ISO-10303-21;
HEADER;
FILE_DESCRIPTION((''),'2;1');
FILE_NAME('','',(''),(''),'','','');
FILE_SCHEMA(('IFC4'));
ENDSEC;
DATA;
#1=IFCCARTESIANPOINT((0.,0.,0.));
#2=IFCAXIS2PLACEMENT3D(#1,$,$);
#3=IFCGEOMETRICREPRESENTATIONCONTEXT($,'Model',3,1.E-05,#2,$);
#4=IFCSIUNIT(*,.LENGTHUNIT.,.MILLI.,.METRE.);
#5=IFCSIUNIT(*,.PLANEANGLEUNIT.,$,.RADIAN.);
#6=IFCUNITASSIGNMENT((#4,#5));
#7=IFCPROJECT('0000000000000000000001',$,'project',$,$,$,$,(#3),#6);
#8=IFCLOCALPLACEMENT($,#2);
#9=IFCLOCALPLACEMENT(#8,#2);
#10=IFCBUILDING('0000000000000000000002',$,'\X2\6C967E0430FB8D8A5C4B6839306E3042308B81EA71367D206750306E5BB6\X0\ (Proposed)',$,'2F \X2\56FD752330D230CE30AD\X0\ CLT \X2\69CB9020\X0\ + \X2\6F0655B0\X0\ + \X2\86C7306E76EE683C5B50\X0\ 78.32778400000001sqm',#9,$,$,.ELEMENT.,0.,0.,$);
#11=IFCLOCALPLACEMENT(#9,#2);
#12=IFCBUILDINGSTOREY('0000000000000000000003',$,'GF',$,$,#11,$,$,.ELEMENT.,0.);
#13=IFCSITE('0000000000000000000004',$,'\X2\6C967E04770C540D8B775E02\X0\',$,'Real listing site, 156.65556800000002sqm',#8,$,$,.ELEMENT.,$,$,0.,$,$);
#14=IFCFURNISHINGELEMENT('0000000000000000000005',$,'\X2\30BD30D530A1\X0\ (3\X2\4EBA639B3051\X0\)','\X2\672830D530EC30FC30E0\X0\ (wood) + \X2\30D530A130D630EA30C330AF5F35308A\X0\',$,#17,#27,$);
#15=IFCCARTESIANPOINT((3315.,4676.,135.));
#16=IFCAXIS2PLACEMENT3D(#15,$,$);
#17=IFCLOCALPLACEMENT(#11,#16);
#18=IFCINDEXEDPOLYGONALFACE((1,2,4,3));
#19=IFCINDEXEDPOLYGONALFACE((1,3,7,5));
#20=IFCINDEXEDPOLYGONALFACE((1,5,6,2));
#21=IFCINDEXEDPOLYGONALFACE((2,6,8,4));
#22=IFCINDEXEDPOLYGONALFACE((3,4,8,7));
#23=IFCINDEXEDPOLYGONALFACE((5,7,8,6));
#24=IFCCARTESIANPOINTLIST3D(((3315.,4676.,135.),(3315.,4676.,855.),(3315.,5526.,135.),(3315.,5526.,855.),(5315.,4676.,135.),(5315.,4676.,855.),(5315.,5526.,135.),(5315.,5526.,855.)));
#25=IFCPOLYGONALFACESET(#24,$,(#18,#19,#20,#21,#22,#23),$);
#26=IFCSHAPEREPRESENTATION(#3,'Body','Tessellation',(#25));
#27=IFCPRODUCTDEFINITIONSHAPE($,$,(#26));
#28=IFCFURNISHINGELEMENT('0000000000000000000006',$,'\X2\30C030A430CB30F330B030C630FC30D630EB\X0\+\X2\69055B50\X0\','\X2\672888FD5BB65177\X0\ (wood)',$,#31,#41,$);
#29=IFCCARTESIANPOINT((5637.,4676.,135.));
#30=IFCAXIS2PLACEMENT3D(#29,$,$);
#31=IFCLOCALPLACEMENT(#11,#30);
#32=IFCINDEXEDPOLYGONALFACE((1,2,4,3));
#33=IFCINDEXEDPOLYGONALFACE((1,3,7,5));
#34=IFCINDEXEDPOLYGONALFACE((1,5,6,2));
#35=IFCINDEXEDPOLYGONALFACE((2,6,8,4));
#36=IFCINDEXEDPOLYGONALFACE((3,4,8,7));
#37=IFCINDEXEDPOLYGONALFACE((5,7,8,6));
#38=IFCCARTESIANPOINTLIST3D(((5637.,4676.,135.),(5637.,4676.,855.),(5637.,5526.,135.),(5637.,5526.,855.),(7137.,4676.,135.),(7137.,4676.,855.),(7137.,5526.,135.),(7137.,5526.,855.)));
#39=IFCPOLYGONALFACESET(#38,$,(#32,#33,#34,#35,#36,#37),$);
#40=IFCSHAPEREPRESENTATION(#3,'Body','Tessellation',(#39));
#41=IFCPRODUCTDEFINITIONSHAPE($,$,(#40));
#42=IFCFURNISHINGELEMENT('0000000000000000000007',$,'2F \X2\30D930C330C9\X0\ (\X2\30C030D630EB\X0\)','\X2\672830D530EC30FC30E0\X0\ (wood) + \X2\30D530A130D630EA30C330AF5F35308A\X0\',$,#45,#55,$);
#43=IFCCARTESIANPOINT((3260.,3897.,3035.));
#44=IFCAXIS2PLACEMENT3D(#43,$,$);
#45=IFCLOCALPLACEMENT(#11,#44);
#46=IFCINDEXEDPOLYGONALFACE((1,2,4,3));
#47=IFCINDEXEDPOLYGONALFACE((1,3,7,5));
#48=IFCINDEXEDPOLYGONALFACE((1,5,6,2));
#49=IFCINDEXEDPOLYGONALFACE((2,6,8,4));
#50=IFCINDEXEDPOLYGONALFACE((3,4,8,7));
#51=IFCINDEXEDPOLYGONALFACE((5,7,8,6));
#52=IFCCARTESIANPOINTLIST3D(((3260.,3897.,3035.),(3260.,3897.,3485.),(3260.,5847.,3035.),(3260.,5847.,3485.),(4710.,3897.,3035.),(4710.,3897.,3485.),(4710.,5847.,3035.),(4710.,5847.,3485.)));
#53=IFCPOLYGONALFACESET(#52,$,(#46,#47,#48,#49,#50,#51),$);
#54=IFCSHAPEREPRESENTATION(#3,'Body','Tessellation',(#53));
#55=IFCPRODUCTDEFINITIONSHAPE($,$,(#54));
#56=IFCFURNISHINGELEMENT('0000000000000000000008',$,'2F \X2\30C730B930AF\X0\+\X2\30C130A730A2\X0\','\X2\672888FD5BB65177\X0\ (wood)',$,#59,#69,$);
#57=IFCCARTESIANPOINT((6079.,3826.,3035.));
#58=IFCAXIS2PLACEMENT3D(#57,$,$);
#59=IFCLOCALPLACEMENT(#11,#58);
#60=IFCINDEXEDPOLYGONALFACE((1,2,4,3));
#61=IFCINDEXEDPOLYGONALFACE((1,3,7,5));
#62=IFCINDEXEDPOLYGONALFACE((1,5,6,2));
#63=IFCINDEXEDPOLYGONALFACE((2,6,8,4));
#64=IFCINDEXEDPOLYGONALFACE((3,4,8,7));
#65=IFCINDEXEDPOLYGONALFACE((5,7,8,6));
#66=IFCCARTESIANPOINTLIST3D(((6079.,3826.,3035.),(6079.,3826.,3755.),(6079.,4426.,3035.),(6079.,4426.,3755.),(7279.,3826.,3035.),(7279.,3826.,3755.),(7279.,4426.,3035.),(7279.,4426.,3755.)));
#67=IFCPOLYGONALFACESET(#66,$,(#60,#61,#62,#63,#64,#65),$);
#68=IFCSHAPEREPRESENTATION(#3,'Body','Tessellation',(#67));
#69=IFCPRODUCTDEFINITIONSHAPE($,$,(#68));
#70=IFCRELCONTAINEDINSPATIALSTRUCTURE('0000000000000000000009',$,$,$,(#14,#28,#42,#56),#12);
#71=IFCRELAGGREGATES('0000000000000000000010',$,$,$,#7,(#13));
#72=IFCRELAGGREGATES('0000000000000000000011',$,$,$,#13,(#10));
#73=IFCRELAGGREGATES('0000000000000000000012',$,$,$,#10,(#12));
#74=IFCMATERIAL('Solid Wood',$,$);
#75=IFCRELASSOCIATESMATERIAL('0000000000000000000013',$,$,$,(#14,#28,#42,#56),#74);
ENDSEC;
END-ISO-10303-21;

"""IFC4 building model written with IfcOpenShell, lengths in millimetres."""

from ifc_helpers import new_model, si_unit, frame, frame_2d, origin, place, context, project, spatial, rectangle, extrude, material, element, save


model = new_model("IFC4")

# Units and contexts
model_context = context("Model", 3, precision=1e-05, world=origin())
ifc_project = project(units=[si_unit("LENGTHUNIT", "METRE", prefix="MILLI"), si_unit("PLANEANGLEUNIT", "RADIAN")], contexts=[model_context])

# Site, building, storey
site_placement = place(None, origin())
site = spatial("IfcSite", under=ifc_project, at=site_placement, Name="沖縄県名護市", ObjectType="Real listing site, 156.65556800000002sqm", CompositionType="ELEMENT", RefElevation=0.0)
building_placement = place(site_placement, origin())
building = spatial("IfcBuilding", under=site, at=building_placement, Name="沖縄・越屋根のある自然素材の家 (Proposed)", ObjectType="2F 国産ヒノキ CLT 構造 + 漆喰 + 蛇の目格子 78.32778400000001sqm", CompositionType="ELEMENT", ElevationOfRefHeight=0.0, ElevationOfTerrain=0.0)
storey_placement = place(building_placement, origin())
storey = spatial("IfcBuildingStorey", under=building, at=storey_placement, Name="GF", CompositionType="ELEMENT", Elevation=0.0)

# Shared definitions
ifc_material_1 = material(Name="Solid Wood")

# Furnishing elements
furnishing_1_placement = place(storey_placement, frame((3315.0, 4676.0, 135.0)))
element("IfcFurnishingElement", 1, at=furnishing_1_placement, inside=storey, material=ifc_material_1, Name="ソファ (3人掛け)", Description="木フレーム (wood) + ファブリック張り", context=model_context, shape_type="SweptSolid", body=[
    extrude(rectangle(XDim=2000.0, YDim=850.0, at=frame_2d((1000.0, 425.0))), frame((3315.0, 4676.0, 135.0)), (0.0, 0.0, 1.0), 720.0),
])
furnishing_2_placement = place(storey_placement, frame((5637.0, 4676.0, 135.0)))
element("IfcFurnishingElement", 2, at=furnishing_2_placement, inside=storey, material=ifc_material_1, Name="ダイニングテーブル+椅子", Description="木製家具 (wood)", context=model_context, shape_type="SweptSolid", body=[
    extrude(rectangle(XDim=1500.0, YDim=850.0, at=frame_2d((750.0, 425.0))), frame((5637.0, 4676.0, 135.0)), (0.0, 0.0, 1.0), 720.0),
])
furnishing_3_placement = place(storey_placement, frame((3260.0, 3897.0, 3035.0)))
element("IfcFurnishingElement", 3, at=furnishing_3_placement, inside=storey, material=ifc_material_1, Name="2F ベッド (ダブル)", Description="木フレーム (wood) + ファブリック張り", context=model_context, shape_type="SweptSolid", body=[
    extrude(rectangle(XDim=1450.0, YDim=1950.0, at=frame_2d((725.0, 975.0))), frame((3260.0, 3897.0, 3035.0)), (0.0, 0.0, 1.0), 450.0),
])
furnishing_4_placement = place(storey_placement, frame((6079.0, 3826.0, 3035.0)))
element("IfcFurnishingElement", 4, at=furnishing_4_placement, inside=storey, material=ifc_material_1, Name="2F デスク+チェア", Description="木製家具 (wood)", context=model_context, shape_type="SweptSolid", body=[
    extrude(rectangle(XDim=1200.0, YDim=600.0, at=frame_2d((600.0, 300.0))), frame((6079.0, 3826.0, 3035.0)), (0.0, 0.0, 1.0), 720.0),
])

save(model, "model.ifc")
